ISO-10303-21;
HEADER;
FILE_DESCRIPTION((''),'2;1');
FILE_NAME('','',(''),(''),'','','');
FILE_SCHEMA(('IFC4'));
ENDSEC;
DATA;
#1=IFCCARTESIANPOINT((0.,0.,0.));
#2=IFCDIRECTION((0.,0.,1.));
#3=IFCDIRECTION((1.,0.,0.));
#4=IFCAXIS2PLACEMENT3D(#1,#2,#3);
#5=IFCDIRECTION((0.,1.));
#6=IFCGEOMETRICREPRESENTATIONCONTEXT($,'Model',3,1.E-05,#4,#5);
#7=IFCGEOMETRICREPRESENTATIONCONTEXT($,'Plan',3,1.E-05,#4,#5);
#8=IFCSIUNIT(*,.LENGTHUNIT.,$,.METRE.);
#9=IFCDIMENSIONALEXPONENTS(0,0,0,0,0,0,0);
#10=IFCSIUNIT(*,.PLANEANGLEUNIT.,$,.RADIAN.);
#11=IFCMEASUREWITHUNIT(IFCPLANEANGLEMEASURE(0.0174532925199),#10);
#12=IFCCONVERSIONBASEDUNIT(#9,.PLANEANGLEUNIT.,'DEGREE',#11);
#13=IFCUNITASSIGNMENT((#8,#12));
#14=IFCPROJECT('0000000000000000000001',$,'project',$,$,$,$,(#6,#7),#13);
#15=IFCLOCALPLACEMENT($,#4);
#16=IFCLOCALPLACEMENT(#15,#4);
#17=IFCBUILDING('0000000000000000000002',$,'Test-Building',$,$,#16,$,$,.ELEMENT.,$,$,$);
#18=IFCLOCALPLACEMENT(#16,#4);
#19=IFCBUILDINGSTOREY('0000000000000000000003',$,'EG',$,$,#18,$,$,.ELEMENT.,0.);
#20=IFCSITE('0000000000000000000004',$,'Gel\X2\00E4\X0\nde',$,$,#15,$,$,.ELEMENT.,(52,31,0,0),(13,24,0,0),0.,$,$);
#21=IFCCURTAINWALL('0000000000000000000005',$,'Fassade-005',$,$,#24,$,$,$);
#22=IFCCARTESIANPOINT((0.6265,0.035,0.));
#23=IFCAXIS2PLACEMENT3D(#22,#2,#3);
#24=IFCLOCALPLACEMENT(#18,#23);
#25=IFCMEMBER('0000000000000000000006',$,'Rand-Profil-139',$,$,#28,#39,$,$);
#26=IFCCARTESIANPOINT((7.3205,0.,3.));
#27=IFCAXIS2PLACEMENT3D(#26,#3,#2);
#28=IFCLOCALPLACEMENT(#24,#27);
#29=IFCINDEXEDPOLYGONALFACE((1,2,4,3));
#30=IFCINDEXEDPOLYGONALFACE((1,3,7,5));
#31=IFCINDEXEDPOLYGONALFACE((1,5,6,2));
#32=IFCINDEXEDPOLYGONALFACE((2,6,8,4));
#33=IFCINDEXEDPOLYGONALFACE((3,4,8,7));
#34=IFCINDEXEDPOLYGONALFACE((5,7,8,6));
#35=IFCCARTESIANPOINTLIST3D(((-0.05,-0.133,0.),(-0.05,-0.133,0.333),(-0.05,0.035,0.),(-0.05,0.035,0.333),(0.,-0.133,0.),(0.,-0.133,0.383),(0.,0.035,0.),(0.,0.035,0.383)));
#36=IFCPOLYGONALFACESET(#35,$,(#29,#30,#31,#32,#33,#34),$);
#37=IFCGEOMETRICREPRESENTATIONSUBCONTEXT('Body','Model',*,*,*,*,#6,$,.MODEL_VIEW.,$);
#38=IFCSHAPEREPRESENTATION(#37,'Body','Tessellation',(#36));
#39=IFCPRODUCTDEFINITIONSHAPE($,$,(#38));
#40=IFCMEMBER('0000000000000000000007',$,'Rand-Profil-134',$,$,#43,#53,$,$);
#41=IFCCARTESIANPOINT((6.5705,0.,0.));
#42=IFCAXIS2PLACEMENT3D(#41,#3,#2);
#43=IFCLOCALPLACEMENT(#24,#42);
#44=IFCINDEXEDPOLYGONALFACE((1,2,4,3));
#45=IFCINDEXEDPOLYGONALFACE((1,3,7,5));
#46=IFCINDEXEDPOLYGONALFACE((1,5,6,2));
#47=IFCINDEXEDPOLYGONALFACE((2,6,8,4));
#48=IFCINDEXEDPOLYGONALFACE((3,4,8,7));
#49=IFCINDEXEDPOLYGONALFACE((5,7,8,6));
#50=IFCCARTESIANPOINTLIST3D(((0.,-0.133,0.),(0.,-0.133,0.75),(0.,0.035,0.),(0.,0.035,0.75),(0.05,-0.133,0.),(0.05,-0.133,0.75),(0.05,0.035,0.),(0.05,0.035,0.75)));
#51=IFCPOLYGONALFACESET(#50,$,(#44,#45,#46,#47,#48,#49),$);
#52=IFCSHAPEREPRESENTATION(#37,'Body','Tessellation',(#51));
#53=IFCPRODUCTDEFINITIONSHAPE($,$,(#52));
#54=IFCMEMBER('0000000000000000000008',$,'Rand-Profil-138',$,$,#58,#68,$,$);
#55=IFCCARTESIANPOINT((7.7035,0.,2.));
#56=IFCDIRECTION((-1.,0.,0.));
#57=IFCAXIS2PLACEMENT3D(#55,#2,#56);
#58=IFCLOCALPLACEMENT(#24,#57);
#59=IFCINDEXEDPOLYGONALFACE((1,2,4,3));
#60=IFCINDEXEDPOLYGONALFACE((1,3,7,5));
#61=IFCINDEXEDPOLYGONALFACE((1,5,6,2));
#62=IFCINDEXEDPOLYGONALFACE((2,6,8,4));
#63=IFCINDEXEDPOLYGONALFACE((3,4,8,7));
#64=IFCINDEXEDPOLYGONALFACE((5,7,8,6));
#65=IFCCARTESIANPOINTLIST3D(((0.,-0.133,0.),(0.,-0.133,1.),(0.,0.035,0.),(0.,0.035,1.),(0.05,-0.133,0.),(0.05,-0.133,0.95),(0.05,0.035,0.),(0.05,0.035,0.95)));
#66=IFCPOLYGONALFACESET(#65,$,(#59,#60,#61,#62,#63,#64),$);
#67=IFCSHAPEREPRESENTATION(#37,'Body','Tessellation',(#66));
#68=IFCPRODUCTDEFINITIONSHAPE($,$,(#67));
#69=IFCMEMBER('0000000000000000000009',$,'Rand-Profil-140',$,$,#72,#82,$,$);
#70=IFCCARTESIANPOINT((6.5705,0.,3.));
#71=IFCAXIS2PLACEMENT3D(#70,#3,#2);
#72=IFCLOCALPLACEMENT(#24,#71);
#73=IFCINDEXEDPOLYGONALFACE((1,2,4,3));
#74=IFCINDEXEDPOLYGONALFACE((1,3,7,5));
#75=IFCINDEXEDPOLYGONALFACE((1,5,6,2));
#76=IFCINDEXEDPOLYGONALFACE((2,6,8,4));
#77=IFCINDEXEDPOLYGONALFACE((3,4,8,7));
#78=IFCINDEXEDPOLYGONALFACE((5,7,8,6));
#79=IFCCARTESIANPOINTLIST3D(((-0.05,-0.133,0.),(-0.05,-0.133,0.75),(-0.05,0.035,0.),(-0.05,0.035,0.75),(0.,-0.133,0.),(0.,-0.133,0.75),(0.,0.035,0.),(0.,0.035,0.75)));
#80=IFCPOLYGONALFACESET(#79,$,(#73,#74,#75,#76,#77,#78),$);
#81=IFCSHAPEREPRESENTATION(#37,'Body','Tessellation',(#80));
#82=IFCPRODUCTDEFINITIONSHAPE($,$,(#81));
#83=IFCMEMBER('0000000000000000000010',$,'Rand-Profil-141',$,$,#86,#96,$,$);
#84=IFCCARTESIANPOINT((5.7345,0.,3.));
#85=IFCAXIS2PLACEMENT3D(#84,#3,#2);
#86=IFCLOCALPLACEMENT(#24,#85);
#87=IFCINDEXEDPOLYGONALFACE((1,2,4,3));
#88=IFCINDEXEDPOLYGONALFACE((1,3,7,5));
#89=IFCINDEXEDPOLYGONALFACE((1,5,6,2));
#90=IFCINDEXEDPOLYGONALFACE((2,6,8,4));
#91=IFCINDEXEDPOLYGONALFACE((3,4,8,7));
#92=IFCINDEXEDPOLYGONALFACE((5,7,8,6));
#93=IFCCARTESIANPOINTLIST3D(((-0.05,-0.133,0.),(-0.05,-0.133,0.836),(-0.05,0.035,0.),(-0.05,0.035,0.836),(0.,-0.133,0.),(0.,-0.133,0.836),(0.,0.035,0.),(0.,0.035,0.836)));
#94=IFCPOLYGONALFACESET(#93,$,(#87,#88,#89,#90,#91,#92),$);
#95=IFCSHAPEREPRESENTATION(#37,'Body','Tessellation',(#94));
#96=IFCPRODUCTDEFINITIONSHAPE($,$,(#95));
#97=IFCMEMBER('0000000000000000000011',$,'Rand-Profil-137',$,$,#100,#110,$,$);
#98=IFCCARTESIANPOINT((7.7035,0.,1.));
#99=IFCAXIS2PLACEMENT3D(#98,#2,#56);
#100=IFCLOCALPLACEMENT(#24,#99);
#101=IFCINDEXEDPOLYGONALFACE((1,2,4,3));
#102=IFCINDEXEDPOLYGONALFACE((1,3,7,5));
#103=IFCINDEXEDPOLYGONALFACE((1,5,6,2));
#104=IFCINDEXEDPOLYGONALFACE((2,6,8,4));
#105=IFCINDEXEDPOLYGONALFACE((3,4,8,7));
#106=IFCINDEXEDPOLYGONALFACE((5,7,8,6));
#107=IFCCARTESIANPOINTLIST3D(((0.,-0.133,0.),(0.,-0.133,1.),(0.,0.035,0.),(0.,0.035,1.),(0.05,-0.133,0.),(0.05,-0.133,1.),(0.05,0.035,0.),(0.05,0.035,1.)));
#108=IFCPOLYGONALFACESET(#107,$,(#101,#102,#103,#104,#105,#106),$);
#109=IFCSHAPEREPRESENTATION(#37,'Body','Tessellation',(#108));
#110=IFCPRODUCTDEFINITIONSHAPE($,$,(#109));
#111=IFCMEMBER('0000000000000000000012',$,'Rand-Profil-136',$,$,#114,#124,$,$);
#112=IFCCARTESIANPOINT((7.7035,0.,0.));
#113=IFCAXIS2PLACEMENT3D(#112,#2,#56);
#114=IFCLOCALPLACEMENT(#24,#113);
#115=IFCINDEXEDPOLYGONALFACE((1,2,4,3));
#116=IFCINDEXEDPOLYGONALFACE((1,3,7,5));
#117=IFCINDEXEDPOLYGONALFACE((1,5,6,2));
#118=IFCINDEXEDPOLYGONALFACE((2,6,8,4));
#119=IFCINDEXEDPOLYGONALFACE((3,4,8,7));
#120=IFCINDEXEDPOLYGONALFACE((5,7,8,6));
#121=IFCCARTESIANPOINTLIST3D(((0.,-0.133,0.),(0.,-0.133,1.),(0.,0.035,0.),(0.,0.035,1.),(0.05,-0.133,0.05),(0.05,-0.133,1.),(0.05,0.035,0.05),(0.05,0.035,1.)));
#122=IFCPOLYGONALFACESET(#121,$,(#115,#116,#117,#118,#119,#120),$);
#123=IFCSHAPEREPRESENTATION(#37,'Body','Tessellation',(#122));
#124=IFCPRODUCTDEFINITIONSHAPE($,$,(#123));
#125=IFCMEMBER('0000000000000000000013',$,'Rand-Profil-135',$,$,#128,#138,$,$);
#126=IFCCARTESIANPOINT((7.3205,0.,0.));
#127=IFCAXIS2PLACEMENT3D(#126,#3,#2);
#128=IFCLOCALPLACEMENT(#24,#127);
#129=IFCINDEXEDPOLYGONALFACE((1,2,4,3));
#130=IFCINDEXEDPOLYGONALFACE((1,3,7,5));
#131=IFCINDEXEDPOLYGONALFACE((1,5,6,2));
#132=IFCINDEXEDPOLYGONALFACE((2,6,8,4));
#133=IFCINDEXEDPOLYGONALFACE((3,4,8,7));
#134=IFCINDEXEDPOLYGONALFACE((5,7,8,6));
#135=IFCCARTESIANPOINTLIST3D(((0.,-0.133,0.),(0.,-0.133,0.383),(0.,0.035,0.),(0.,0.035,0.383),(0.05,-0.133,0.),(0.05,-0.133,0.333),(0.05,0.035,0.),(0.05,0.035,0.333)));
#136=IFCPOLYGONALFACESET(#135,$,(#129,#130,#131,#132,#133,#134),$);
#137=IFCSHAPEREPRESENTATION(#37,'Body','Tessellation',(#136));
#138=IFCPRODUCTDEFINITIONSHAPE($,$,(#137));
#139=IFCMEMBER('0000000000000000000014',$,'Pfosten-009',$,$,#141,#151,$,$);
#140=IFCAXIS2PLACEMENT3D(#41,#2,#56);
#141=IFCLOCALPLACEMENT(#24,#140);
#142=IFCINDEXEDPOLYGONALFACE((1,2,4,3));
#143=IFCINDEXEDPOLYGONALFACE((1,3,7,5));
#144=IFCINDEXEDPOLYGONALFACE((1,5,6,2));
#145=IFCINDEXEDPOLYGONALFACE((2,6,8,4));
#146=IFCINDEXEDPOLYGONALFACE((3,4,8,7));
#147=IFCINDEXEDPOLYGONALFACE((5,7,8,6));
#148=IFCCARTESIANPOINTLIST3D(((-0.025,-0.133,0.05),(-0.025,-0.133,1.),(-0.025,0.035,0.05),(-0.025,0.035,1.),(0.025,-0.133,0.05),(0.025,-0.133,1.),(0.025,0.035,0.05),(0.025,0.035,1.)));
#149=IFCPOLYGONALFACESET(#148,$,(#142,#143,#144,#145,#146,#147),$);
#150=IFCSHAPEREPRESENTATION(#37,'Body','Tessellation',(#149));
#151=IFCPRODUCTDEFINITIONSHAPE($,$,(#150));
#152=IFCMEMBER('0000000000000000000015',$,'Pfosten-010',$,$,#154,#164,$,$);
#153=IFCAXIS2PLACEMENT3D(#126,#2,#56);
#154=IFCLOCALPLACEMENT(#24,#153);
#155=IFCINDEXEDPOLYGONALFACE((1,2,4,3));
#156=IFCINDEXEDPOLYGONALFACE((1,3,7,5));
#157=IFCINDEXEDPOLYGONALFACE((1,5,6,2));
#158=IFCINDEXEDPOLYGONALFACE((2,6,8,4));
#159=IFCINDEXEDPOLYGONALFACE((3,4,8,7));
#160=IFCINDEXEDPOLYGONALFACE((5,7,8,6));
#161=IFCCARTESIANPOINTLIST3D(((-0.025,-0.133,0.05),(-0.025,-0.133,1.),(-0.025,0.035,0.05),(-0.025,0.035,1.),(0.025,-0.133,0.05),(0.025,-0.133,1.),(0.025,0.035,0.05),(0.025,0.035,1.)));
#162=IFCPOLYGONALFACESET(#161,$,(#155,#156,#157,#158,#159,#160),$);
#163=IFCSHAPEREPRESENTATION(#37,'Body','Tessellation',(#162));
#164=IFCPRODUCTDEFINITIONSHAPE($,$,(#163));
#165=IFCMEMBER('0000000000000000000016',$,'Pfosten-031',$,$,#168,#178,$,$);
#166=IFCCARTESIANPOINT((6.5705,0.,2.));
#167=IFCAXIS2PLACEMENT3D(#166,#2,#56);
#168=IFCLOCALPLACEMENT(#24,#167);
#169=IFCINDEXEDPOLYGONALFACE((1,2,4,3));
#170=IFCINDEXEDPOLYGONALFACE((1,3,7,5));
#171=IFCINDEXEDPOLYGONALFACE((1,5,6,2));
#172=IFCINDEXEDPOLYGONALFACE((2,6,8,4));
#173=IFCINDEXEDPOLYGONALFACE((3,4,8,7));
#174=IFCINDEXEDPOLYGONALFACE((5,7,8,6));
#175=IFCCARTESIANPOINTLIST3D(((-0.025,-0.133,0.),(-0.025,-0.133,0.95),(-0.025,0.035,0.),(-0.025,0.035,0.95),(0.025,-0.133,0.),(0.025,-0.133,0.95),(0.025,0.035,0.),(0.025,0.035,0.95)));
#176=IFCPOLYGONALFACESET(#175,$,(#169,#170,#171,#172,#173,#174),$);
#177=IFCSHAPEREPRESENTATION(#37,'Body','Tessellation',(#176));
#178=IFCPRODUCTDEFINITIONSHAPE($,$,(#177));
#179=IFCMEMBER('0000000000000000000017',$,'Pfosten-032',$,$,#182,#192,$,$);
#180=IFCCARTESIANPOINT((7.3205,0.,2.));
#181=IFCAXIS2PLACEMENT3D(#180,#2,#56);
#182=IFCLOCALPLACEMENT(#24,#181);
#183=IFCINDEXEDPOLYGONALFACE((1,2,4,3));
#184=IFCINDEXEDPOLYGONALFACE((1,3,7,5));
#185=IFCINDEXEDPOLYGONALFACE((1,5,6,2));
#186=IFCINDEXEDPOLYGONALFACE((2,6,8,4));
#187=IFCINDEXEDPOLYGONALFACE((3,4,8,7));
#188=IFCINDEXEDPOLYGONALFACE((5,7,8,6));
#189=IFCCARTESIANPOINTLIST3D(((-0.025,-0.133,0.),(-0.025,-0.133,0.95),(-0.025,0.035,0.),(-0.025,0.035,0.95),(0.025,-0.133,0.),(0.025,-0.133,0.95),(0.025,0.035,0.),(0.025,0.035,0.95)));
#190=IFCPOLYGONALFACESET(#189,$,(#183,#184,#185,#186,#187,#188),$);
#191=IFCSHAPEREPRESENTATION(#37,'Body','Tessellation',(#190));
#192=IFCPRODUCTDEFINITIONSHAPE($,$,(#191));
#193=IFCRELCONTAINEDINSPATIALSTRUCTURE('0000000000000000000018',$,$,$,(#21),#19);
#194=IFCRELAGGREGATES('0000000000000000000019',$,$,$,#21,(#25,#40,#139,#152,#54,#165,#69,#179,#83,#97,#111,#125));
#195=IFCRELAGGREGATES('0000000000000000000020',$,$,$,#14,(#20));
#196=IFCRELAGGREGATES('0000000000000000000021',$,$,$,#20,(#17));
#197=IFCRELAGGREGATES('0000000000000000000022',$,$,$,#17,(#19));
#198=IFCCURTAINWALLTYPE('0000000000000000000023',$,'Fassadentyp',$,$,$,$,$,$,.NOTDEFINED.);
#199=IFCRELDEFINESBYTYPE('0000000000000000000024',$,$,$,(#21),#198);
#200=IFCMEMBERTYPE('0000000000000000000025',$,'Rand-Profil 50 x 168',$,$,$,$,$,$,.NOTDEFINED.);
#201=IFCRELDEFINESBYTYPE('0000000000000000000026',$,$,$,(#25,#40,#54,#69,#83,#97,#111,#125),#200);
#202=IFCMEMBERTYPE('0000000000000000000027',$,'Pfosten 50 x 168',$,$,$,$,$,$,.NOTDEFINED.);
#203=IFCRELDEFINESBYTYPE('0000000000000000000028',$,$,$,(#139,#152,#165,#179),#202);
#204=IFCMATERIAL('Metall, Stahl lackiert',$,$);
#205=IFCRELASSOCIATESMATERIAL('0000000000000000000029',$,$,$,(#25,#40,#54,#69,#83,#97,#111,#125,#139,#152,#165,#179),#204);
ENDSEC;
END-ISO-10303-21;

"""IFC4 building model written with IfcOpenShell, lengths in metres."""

from ifc_helpers import new_model, entity, si_unit, converted_unit, direction, frame, origin_with_axes, place, context, subcontext, project, spatial, polyline, outline, extrude, clip, halfspace, material, type_object, element, aggregate, save


model = new_model("IFC4")

# Units and contexts
model_context = context("Model", 3, precision=1e-05, world=origin_with_axes(), true_north=direction((0.0, 1.0)))
plan_context = context("Plan", 3, precision=1e-05, world=origin_with_axes(), true_north=direction((0.0, 1.0)))
body_context = subcontext(model_context, "Body", "Model", "MODEL_VIEW")
ifc_project = project(units=[si_unit("LENGTHUNIT", "METRE"), converted_unit("PLANEANGLEUNIT", "DEGREE", entity("IfcPlaneAngleMeasure", 0.0174532925199), si_unit("PLANEANGLEUNIT", "RADIAN"), dimensions=[0, 0, 0, 0, 0, 0, 0])], contexts=[model_context, plan_context])

# Site, building, storey
site_placement = place(None, origin_with_axes())
site = spatial("IfcSite", under=ifc_project, at=site_placement, Name="Gelände", CompositionType="ELEMENT", RefLatitude=(52, 31, 0, 0), RefLongitude=(13, 24, 0, 0), RefElevation=0.0)
building_placement = place(site_placement, origin_with_axes())
building = spatial("IfcBuilding", under=site, at=building_placement, Name="Test-Building", CompositionType="ELEMENT")
storey_placement = place(building_placement, origin_with_axes())
storey = spatial("IfcBuildingStorey", under=building, at=storey_placement, Name="EG", CompositionType="ELEMENT", Elevation=0.0)

# Curtain wall, members
curtain_wall_type = type_object("IfcCurtainWallType", Name="Fassadentyp", PredefinedType="NOTDEFINED")
curtain_wall_placement = place(storey_placement, frame((0.6265, 0.035, 0.0), z_axis=(0.0, 0.0, 1.0), x_axis=(1.0, 0.0, 0.0)))
curtain_wall = element("IfcCurtainWall", 1, at=curtain_wall_placement, inside=storey, type_object=curtain_wall_type, Name="Fassade-005")
ifc_material_1 = material(Name="Metall, Stahl lackiert")
member_type_1 = type_object("IfcMemberType", Name="Rand-Profil 50 x 168", PredefinedType="NOTDEFINED")
member_1_placement = place(curtain_wall_placement, frame((7.3205, 0.0, 3.0), z_axis=(1.0, 0.0, 0.0), x_axis=(0.0, 0.0, 1.0)))
member_1 = element("IfcMember", 2, at=member_1_placement, type_object=member_type_1, material=ifc_material_1, Name="Rand-Profil-139", context=body_context, shape_type="Clipping", body=[
    clip(extrude(outline(polyline([(-0.133, 0.05), (-0.133, 0.0), (0.035, 0.0), (0.035, 0.05), (-0.133, 0.05)])), frame((0.0, 0.0, 0.0), z_axis=(0.0, 0.0, 1.0), x_axis=(0.0, 1.0, 0.0)), (0.0, 0.0, 1.0), 0.383), halfspace(frame((-0.1915, 0.0, 0.1915), z_axis=(0.707107, 0.0, -0.707107), x_axis=(0.0, 1.0, 0.0)), True)),
])
member_2_placement = place(curtain_wall_placement, frame((6.5705, 0.0, 0.0), z_axis=(1.0, 0.0, 0.0), x_axis=(0.0, 0.0, 1.0)))
member_2 = element("IfcMember", 3, at=member_2_placement, type_object=member_type_1, material=ifc_material_1, Name="Rand-Profil-134", context=body_context, shape_type="SweptSolid", body=[
    extrude(outline(polyline([(-0.133, -0.05), (0.035, -0.05), (0.035, 0.0), (-0.133, 0.0), (-0.133, -0.05)])), frame((0.0, 0.0, 0.0), z_axis=(0.0, 0.0, 1.0), x_axis=(0.0, 1.0, 0.0)), (0.0, 0.0, 1.0), 0.75),
])
member_3_placement = place(curtain_wall_placement, frame((7.7035, 0.0, 2.0), z_axis=(0.0, 0.0, 1.0), x_axis=(-1.0, 0.0, 0.0)))
member_3 = element("IfcMember", 4, at=member_3_placement, type_object=member_type_1, material=ifc_material_1, Name="Rand-Profil-138", context=body_context, shape_type="Clipping", body=[
    clip(extrude(outline(polyline([(-0.05, 0.133), (-0.05, -0.035), (0.0, -0.035), (0.0, 0.133), (-0.05, 0.133)])), frame((0.0, 0.0, 0.0), z_axis=(0.0, 0.0, 1.0), x_axis=(-1.0, 0.0, 0.0)), (0.0, 0.0, 1.0), 1.0), halfspace(frame((0.5, 0.0, 0.5), z_axis=(-0.707107, 0.0, -0.707107), x_axis=(0.0, 1.0, 0.0)), True)),
])
member_4_placement = place(curtain_wall_placement, frame((6.5705, 0.0, 3.0), z_axis=(1.0, 0.0, 0.0), x_axis=(0.0, 0.0, 1.0)))
member_4 = element("IfcMember", 5, at=member_4_placement, type_object=member_type_1, material=ifc_material_1, Name="Rand-Profil-140", context=body_context, shape_type="SweptSolid", body=[
    extrude(outline(polyline([(-0.133, 0.05), (-0.133, 0.0), (0.035, 0.0), (0.035, 0.05), (-0.133, 0.05)])), frame((0.0, 0.0, 0.0), z_axis=(0.0, 0.0, 1.0), x_axis=(0.0, 1.0, 0.0)), (0.0, 0.0, 1.0), 0.75),
])
member_5_placement = place(curtain_wall_placement, frame((5.7345, 0.0, 3.0), z_axis=(1.0, 0.0, 0.0), x_axis=(0.0, 0.0, 1.0)))
member_5 = element("IfcMember", 6, at=member_5_placement, type_object=member_type_1, material=ifc_material_1, Name="Rand-Profil-141", context=body_context, shape_type="SweptSolid", body=[
    extrude(outline(polyline([(-0.133, 0.05), (-0.133, 0.0), (0.035, 0.0), (0.035, 0.05), (-0.133, 0.05)])), frame((0.0, 0.0, 0.0), z_axis=(0.0, 0.0, 1.0), x_axis=(0.0, 1.0, 0.0)), (0.0, 0.0, 1.0), 0.836),
])
member_6_placement = place(curtain_wall_placement, frame((7.7035, 0.0, 1.0), z_axis=(0.0, 0.0, 1.0), x_axis=(-1.0, 0.0, 0.0)))
member_6 = element("IfcMember", 7, at=member_6_placement, type_object=member_type_1, material=ifc_material_1, Name="Rand-Profil-137", context=body_context, shape_type="SweptSolid", body=[
    extrude(outline(polyline([(-0.05, 0.133), (-0.05, -0.035), (0.0, -0.035), (0.0, 0.133), (-0.05, 0.133)])), frame((0.0, 0.0, 0.0), z_axis=(0.0, 0.0, 1.0), x_axis=(-1.0, 0.0, 0.0)), (0.0, 0.0, 1.0), 1.0),
])
member_7_placement = place(curtain_wall_placement, frame((7.7035, 0.0, 0.0), z_axis=(0.0, 0.0, 1.0), x_axis=(-1.0, 0.0, 0.0)))
member_7 = element("IfcMember", 8, at=member_7_placement, type_object=member_type_1, material=ifc_material_1, Name="Rand-Profil-136", context=body_context, shape_type="Clipping", body=[
    clip(extrude(outline(polyline([(-0.05, 0.133), (-0.05, -0.035), (0.0, -0.035), (0.0, 0.133), (-0.05, 0.133)])), frame((0.0, 0.0, 0.0), z_axis=(0.0, 0.0, 1.0), x_axis=(-1.0, 0.0, 0.0)), (0.0, 0.0, 1.0), 1.0), halfspace(frame((0.0, 0.0, 0.0), z_axis=(-0.707107, 0.0, 0.707107), x_axis=(0.0, -1.0, 0.0)), True)),
])
member_8_placement = place(curtain_wall_placement, frame((7.3205, 0.0, 0.0), z_axis=(1.0, 0.0, 0.0), x_axis=(0.0, 0.0, 1.0)))
member_8 = element("IfcMember", 9, at=member_8_placement, type_object=member_type_1, material=ifc_material_1, Name="Rand-Profil-135", context=body_context, shape_type="Clipping", body=[
    clip(extrude(outline(polyline([(-0.133, -0.05), (0.035, -0.05), (0.035, 0.0), (-0.133, 0.0), (-0.133, -0.05)])), frame((0.0, 0.0, 0.0), z_axis=(0.0, 0.0, 1.0), x_axis=(0.0, 1.0, 0.0)), (0.0, 0.0, 1.0), 0.383), halfspace(frame((0.1915, 0.0, 0.1915), z_axis=(-0.707107, 0.0, -0.707107), x_axis=(0.0, 1.0, 0.0)), True)),
])
member_type_2 = type_object("IfcMemberType", Name="Pfosten 50 x 168", PredefinedType="NOTDEFINED")
member_9_placement = place(curtain_wall_placement, frame((6.5705, 0.0, 0.0), z_axis=(0.0, 0.0, 1.0), x_axis=(-1.0, 0.0, 0.0)))
member_9 = element("IfcMember", 10, at=member_9_placement, type_object=member_type_2, material=ifc_material_1, Name="Pfosten-009", context=body_context, shape_type="SweptSolid", body=[
    extrude(outline(polyline([(-0.025, 0.133), (-0.025, -0.035), (0.025, -0.035), (0.025, 0.133), (-0.025, 0.133)])), frame((0.0, 0.0, 0.05), z_axis=(0.0, 0.0, 1.0), x_axis=(-1.0, 0.0, 0.0)), (0.0, 0.0, 1.0), 0.95),
])
member_10_placement = place(curtain_wall_placement, frame((7.3205, 0.0, 0.0), z_axis=(0.0, 0.0, 1.0), x_axis=(-1.0, 0.0, 0.0)))
member_10 = element("IfcMember", 11, at=member_10_placement, type_object=member_type_2, material=ifc_material_1, Name="Pfosten-010", context=body_context, shape_type="SweptSolid", body=[
    extrude(outline(polyline([(-0.025, 0.133), (-0.025, -0.035), (0.025, -0.035), (0.025, 0.133), (-0.025, 0.133)])), frame((0.0, 0.0, 0.05), z_axis=(0.0, 0.0, 1.0), x_axis=(-1.0, 0.0, 0.0)), (0.0, 0.0, 1.0), 0.95),
])
member_11_placement = place(curtain_wall_placement, frame((6.5705, 0.0, 2.0), z_axis=(0.0, 0.0, 1.0), x_axis=(-1.0, 0.0, 0.0)))
member_11 = element("IfcMember", 12, at=member_11_placement, type_object=member_type_2, material=ifc_material_1, Name="Pfosten-031", context=body_context, shape_type="SweptSolid", body=[
    extrude(outline(polyline([(-0.025, 0.133), (-0.025, -0.035), (0.025, -0.035), (0.025, 0.133), (-0.025, 0.133)])), frame((0.0, 0.0, 0.0), z_axis=(0.0, 0.0, 1.0), x_axis=(-1.0, 0.0, 0.0)), (0.0, 0.0, 1.0), 0.95),
])
member_12_placement = place(curtain_wall_placement, frame((7.3205, 0.0, 2.0), z_axis=(0.0, 0.0, 1.0), x_axis=(-1.0, 0.0, 0.0)))
member_12 = element("IfcMember", 13, at=member_12_placement, type_object=member_type_2, material=ifc_material_1, Name="Pfosten-032", context=body_context, shape_type="SweptSolid", body=[
    extrude(outline(polyline([(-0.025, 0.133), (-0.025, -0.035), (0.025, -0.035), (0.025, 0.133), (-0.025, 0.133)])), frame((0.0, 0.0, 0.0), z_axis=(0.0, 0.0, 1.0), x_axis=(-1.0, 0.0, 0.0)), (0.0, 0.0, 1.0), 0.95),
])
aggregate(curtain_wall, [member_1, member_2, member_9, member_10, member_3, member_11, member_4, member_12, member_5, member_6, member_7, member_8])

save(model, "model.ifc")
